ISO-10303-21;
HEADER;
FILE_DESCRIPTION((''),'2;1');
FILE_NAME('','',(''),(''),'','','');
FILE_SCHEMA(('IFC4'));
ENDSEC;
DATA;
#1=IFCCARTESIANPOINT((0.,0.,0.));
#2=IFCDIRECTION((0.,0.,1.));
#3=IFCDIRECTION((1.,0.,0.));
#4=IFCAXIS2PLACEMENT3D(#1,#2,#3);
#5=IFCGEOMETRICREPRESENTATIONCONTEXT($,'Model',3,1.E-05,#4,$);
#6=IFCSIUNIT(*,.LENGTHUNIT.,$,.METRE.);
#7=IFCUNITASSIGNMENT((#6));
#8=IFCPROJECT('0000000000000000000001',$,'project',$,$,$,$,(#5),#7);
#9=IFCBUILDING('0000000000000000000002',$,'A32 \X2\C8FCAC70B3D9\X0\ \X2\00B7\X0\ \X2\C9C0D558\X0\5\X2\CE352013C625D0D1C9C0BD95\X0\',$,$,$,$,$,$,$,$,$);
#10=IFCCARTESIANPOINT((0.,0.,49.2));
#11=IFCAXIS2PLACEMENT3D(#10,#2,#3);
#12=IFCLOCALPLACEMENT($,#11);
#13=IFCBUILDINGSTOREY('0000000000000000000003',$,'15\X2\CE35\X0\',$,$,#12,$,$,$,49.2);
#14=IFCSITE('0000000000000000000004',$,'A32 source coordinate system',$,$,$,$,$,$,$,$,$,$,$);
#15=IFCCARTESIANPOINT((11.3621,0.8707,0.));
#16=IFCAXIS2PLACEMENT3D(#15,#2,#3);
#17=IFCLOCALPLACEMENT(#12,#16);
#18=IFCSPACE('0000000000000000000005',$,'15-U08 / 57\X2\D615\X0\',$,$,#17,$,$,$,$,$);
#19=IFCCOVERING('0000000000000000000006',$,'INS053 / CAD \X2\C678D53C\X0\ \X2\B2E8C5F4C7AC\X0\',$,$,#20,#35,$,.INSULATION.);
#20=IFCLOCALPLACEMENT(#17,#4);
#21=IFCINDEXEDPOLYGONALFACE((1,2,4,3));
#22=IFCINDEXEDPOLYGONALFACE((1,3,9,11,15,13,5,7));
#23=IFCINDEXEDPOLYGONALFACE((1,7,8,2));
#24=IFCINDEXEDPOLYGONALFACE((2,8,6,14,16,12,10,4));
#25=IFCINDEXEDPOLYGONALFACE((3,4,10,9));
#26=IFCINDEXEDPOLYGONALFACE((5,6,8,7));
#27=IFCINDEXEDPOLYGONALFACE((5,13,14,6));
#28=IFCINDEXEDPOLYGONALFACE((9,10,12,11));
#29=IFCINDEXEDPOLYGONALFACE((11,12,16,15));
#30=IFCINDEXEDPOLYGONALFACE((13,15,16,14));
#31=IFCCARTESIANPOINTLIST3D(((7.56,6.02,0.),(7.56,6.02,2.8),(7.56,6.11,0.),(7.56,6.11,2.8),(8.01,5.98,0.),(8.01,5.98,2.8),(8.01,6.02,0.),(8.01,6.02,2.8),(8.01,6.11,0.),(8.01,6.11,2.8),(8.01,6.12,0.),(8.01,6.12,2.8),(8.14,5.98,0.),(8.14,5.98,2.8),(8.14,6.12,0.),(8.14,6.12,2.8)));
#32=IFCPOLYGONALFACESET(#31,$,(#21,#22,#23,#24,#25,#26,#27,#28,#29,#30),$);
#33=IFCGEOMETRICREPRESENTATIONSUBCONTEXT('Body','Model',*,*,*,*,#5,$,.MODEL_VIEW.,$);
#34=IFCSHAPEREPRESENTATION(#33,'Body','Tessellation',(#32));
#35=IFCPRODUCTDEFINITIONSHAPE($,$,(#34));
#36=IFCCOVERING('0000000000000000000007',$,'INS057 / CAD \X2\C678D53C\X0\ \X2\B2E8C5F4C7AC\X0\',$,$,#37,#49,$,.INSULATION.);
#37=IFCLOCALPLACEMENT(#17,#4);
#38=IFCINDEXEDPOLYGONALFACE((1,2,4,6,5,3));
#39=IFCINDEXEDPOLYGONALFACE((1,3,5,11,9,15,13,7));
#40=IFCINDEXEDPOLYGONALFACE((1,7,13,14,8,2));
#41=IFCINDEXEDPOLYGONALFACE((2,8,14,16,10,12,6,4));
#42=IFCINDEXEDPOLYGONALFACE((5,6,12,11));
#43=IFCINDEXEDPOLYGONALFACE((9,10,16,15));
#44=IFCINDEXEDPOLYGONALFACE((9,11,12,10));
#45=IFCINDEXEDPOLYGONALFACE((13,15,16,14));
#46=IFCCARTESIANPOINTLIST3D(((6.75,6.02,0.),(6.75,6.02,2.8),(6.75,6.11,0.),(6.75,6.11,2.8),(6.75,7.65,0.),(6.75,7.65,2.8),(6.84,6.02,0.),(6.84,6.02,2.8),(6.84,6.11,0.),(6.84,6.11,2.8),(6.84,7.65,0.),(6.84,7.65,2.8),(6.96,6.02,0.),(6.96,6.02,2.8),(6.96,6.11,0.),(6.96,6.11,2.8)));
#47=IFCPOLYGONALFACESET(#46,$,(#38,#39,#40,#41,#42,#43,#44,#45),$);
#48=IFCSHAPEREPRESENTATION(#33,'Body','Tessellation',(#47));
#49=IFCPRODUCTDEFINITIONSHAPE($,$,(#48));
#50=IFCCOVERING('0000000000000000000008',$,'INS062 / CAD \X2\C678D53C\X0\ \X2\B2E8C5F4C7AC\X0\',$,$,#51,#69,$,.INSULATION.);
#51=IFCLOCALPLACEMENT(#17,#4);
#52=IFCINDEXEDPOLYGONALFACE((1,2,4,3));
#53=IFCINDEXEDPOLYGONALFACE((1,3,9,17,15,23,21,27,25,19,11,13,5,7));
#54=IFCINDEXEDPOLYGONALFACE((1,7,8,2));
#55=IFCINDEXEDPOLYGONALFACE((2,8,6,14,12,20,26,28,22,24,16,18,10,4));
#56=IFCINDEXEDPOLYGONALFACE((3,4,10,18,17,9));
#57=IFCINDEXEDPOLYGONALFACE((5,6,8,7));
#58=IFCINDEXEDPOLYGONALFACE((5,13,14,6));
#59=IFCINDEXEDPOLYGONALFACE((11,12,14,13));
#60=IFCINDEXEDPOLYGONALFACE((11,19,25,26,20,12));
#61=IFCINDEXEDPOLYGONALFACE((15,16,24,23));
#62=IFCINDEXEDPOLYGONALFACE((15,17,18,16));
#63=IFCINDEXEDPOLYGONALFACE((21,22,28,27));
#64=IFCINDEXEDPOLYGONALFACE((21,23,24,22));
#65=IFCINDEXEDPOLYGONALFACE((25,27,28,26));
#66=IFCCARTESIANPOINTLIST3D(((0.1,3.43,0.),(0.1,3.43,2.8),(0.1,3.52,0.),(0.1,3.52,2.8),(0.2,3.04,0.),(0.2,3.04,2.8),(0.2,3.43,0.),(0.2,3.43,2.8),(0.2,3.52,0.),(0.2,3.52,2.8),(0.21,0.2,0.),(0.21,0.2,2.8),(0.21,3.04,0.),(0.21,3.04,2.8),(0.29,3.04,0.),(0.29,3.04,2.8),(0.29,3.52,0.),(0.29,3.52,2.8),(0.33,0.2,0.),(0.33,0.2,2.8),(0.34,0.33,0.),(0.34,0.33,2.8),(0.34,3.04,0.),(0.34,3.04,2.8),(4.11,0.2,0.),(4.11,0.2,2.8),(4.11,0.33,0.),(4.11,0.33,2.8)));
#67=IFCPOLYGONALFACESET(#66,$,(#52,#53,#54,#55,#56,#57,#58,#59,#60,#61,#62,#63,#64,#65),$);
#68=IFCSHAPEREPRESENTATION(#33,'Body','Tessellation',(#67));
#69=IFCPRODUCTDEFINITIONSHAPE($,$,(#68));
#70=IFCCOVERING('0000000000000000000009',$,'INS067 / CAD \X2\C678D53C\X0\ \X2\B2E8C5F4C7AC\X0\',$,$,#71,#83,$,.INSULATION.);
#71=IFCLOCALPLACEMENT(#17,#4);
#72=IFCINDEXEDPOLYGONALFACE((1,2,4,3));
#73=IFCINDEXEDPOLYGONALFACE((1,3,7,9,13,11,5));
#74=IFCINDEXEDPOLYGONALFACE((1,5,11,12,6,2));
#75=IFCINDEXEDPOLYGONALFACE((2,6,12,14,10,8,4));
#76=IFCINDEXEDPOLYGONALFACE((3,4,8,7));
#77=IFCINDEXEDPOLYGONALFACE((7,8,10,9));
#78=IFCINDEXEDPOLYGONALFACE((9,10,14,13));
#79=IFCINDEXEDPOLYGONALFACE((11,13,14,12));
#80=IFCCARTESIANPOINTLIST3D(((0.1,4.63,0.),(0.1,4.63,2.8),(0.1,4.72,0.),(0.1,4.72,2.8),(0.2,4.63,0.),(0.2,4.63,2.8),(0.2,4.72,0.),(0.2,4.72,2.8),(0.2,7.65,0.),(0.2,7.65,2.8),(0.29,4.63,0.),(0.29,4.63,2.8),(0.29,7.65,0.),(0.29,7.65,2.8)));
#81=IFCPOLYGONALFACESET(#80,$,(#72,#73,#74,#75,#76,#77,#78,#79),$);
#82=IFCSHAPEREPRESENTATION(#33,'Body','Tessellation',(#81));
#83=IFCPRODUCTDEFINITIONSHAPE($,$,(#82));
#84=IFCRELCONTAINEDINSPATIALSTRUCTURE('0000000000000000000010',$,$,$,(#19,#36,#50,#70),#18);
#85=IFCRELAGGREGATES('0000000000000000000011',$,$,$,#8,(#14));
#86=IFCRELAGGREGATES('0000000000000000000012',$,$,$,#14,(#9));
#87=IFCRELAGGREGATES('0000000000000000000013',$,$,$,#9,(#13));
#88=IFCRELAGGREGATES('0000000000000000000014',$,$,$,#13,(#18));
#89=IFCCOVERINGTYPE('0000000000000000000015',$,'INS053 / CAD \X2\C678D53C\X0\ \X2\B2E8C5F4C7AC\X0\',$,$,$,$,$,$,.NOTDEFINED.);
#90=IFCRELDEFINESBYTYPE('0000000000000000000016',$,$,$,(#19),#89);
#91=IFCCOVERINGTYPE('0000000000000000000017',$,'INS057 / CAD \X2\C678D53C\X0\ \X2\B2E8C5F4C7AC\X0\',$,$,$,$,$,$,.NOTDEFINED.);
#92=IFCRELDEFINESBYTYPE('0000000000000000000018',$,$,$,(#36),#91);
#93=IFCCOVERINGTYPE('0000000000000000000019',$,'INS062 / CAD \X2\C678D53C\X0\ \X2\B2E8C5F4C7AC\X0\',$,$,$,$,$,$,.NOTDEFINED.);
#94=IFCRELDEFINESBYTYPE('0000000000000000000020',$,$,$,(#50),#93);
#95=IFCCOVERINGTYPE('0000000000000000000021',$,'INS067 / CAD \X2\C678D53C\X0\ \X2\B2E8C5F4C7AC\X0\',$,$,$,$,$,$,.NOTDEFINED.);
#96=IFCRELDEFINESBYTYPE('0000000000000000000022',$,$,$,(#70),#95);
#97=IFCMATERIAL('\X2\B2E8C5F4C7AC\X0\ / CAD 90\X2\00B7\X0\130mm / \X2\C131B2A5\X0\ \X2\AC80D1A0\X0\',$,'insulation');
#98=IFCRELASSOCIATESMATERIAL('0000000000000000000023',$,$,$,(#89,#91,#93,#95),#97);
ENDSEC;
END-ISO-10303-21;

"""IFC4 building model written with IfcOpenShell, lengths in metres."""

from ifc_helpers import new_model, si_unit, frame, origin, origin_with_axes, place, context, subcontext, project, spatial, polyline, outline, extrude, source, transform, mapped, material, type_object, type_shapes, element, save


model = new_model("IFC4")

# Units and contexts
model_context = context("Model", 3, precision=1e-05, world=origin_with_axes())
body_context = subcontext(model_context, "Body", "Model", "MODEL_VIEW")
ifc_project = project(units=[si_unit("LENGTHUNIT", "METRE")], contexts=[model_context])

# Site, building, storey, space
site = spatial("IfcSite", under=ifc_project, Name="A32 source coordinate system")
building = spatial("IfcBuilding", under=site, Name="A32 주거동 · 지하5층–옥탑지붕")
storey_placement = place(None, frame((0.0, 0.0, 49.2), z_axis=(0.0, 0.0, 1.0), x_axis=(1.0, 0.0, 0.0)))
storey = spatial("IfcBuildingStorey", under=building, at=storey_placement, Name="15층", Elevation=49.2)
space_1_placement = place(storey_placement, frame((11.3621, 0.8707, 0.0), z_axis=(0.0, 0.0, 1.0), x_axis=(1.0, 0.0, 0.0)))
space_1 = spatial("IfcSpace", under=storey, at=space_1_placement, Name="15-U08 / 57형")

# Coverings
ifc_material = material(Name="단열재 / CAD 90·130mm / 성능 검토", Category="insulation")
covering_type_1 = type_object("IfcCoveringType", Name="INS053 / CAD 외피 단열재", PredefinedType="NOTDEFINED", material=ifc_material)
shared_shape_1 = source(origin(), body_context, "Body", "SweptSolid", [
    extrude(outline(polyline([(8.01, 6.12), (8.14, 6.12), (8.14, 5.98), (8.01, 5.98), (8.01, 6.02), (7.56, 6.02), (7.56, 6.11), (8.01, 6.11), (8.01, 6.12)])), origin(), (0.0, 0.0, 1.0), 2.8),
])
type_shapes(covering_type_1, [shared_shape_1])
covering_1_placement = place(space_1_placement, origin_with_axes())
element("IfcCovering", 1, at=covering_1_placement, inside=space_1, type_object=covering_type_1, Name="INS053 / CAD 외피 단열재", PredefinedType="INSULATION", context=body_context, shape_type="MappedRepresentation", body=[
    mapped(shared_shape_1, transform((0.0, 0.0, 0.0), scale=1.0)),
])
covering_type_2 = type_object("IfcCoveringType", Name="INS057 / CAD 외피 단열재", PredefinedType="NOTDEFINED", material=ifc_material)
shared_shape_2 = source(origin(), body_context, "Body", "SweptSolid", [
    extrude(outline(polyline([(6.84, 6.11), (6.96, 6.11), (6.96, 6.02), (6.84, 6.02), (6.75, 6.02), (6.75, 6.11), (6.75, 7.65), (6.84, 7.65), (6.84, 6.11)])), origin(), (0.0, 0.0, 1.0), 2.8),
])
type_shapes(covering_type_2, [shared_shape_2])
covering_2_placement = place(space_1_placement, origin_with_axes())
element("IfcCovering", 2, at=covering_2_placement, inside=space_1, type_object=covering_type_2, Name="INS057 / CAD 외피 단열재", PredefinedType="INSULATION", context=body_context, shape_type="MappedRepresentation", body=[
    mapped(shared_shape_2, transform((0.0, 0.0, 0.0), scale=1.0)),
])
covering_type_3 = type_object("IfcCoveringType", Name="INS062 / CAD 외피 단열재", PredefinedType="NOTDEFINED", material=ifc_material)
shared_shape_3 = source(origin(), body_context, "Body", "SweptSolid", [
    extrude(outline(polyline([(4.11, 0.2), (0.33, 0.2), (0.21, 0.2), (0.21, 3.04), (0.2, 3.04), (0.2, 3.43), (0.1, 3.43), (0.1, 3.52), (0.2, 3.52), (0.29, 3.52), (0.29, 3.04), (0.34, 3.04), (0.34, 0.33), (4.11, 0.33), (4.11, 0.2)])), origin(), (0.0, 0.0, 1.0), 2.8),
])
type_shapes(covering_type_3, [shared_shape_3])
covering_3_placement = place(space_1_placement, origin_with_axes())
element("IfcCovering", 3, at=covering_3_placement, inside=space_1, type_object=covering_type_3, Name="INS062 / CAD 외피 단열재", PredefinedType="INSULATION", context=body_context, shape_type="MappedRepresentation", body=[
    mapped(shared_shape_3, transform((0.0, 0.0, 0.0), scale=1.0)),
])
covering_type_4 = type_object("IfcCoveringType", Name="INS067 / CAD 외피 단열재", PredefinedType="NOTDEFINED", material=ifc_material)
shared_shape_4 = source(origin(), body_context, "Body", "SweptSolid", [
    extrude(outline(polyline([(0.1, 4.72), (0.2, 4.72), (0.2, 7.65), (0.29, 7.65), (0.29, 4.63), (0.2, 4.63), (0.1, 4.63), (0.1, 4.72)])), origin(), (0.0, 0.0, 1.0), 2.8),
])
type_shapes(covering_type_4, [shared_shape_4])
covering_4_placement = place(space_1_placement, origin_with_axes())
element("IfcCovering", 4, at=covering_4_placement, inside=space_1, type_object=covering_type_4, Name="INS067 / CAD 외피 단열재", PredefinedType="INSULATION", context=body_context, shape_type="MappedRepresentation", body=[
    mapped(shared_shape_4, transform((0.0, 0.0, 0.0), scale=1.0)),
])

save(model, "model.ifc")
